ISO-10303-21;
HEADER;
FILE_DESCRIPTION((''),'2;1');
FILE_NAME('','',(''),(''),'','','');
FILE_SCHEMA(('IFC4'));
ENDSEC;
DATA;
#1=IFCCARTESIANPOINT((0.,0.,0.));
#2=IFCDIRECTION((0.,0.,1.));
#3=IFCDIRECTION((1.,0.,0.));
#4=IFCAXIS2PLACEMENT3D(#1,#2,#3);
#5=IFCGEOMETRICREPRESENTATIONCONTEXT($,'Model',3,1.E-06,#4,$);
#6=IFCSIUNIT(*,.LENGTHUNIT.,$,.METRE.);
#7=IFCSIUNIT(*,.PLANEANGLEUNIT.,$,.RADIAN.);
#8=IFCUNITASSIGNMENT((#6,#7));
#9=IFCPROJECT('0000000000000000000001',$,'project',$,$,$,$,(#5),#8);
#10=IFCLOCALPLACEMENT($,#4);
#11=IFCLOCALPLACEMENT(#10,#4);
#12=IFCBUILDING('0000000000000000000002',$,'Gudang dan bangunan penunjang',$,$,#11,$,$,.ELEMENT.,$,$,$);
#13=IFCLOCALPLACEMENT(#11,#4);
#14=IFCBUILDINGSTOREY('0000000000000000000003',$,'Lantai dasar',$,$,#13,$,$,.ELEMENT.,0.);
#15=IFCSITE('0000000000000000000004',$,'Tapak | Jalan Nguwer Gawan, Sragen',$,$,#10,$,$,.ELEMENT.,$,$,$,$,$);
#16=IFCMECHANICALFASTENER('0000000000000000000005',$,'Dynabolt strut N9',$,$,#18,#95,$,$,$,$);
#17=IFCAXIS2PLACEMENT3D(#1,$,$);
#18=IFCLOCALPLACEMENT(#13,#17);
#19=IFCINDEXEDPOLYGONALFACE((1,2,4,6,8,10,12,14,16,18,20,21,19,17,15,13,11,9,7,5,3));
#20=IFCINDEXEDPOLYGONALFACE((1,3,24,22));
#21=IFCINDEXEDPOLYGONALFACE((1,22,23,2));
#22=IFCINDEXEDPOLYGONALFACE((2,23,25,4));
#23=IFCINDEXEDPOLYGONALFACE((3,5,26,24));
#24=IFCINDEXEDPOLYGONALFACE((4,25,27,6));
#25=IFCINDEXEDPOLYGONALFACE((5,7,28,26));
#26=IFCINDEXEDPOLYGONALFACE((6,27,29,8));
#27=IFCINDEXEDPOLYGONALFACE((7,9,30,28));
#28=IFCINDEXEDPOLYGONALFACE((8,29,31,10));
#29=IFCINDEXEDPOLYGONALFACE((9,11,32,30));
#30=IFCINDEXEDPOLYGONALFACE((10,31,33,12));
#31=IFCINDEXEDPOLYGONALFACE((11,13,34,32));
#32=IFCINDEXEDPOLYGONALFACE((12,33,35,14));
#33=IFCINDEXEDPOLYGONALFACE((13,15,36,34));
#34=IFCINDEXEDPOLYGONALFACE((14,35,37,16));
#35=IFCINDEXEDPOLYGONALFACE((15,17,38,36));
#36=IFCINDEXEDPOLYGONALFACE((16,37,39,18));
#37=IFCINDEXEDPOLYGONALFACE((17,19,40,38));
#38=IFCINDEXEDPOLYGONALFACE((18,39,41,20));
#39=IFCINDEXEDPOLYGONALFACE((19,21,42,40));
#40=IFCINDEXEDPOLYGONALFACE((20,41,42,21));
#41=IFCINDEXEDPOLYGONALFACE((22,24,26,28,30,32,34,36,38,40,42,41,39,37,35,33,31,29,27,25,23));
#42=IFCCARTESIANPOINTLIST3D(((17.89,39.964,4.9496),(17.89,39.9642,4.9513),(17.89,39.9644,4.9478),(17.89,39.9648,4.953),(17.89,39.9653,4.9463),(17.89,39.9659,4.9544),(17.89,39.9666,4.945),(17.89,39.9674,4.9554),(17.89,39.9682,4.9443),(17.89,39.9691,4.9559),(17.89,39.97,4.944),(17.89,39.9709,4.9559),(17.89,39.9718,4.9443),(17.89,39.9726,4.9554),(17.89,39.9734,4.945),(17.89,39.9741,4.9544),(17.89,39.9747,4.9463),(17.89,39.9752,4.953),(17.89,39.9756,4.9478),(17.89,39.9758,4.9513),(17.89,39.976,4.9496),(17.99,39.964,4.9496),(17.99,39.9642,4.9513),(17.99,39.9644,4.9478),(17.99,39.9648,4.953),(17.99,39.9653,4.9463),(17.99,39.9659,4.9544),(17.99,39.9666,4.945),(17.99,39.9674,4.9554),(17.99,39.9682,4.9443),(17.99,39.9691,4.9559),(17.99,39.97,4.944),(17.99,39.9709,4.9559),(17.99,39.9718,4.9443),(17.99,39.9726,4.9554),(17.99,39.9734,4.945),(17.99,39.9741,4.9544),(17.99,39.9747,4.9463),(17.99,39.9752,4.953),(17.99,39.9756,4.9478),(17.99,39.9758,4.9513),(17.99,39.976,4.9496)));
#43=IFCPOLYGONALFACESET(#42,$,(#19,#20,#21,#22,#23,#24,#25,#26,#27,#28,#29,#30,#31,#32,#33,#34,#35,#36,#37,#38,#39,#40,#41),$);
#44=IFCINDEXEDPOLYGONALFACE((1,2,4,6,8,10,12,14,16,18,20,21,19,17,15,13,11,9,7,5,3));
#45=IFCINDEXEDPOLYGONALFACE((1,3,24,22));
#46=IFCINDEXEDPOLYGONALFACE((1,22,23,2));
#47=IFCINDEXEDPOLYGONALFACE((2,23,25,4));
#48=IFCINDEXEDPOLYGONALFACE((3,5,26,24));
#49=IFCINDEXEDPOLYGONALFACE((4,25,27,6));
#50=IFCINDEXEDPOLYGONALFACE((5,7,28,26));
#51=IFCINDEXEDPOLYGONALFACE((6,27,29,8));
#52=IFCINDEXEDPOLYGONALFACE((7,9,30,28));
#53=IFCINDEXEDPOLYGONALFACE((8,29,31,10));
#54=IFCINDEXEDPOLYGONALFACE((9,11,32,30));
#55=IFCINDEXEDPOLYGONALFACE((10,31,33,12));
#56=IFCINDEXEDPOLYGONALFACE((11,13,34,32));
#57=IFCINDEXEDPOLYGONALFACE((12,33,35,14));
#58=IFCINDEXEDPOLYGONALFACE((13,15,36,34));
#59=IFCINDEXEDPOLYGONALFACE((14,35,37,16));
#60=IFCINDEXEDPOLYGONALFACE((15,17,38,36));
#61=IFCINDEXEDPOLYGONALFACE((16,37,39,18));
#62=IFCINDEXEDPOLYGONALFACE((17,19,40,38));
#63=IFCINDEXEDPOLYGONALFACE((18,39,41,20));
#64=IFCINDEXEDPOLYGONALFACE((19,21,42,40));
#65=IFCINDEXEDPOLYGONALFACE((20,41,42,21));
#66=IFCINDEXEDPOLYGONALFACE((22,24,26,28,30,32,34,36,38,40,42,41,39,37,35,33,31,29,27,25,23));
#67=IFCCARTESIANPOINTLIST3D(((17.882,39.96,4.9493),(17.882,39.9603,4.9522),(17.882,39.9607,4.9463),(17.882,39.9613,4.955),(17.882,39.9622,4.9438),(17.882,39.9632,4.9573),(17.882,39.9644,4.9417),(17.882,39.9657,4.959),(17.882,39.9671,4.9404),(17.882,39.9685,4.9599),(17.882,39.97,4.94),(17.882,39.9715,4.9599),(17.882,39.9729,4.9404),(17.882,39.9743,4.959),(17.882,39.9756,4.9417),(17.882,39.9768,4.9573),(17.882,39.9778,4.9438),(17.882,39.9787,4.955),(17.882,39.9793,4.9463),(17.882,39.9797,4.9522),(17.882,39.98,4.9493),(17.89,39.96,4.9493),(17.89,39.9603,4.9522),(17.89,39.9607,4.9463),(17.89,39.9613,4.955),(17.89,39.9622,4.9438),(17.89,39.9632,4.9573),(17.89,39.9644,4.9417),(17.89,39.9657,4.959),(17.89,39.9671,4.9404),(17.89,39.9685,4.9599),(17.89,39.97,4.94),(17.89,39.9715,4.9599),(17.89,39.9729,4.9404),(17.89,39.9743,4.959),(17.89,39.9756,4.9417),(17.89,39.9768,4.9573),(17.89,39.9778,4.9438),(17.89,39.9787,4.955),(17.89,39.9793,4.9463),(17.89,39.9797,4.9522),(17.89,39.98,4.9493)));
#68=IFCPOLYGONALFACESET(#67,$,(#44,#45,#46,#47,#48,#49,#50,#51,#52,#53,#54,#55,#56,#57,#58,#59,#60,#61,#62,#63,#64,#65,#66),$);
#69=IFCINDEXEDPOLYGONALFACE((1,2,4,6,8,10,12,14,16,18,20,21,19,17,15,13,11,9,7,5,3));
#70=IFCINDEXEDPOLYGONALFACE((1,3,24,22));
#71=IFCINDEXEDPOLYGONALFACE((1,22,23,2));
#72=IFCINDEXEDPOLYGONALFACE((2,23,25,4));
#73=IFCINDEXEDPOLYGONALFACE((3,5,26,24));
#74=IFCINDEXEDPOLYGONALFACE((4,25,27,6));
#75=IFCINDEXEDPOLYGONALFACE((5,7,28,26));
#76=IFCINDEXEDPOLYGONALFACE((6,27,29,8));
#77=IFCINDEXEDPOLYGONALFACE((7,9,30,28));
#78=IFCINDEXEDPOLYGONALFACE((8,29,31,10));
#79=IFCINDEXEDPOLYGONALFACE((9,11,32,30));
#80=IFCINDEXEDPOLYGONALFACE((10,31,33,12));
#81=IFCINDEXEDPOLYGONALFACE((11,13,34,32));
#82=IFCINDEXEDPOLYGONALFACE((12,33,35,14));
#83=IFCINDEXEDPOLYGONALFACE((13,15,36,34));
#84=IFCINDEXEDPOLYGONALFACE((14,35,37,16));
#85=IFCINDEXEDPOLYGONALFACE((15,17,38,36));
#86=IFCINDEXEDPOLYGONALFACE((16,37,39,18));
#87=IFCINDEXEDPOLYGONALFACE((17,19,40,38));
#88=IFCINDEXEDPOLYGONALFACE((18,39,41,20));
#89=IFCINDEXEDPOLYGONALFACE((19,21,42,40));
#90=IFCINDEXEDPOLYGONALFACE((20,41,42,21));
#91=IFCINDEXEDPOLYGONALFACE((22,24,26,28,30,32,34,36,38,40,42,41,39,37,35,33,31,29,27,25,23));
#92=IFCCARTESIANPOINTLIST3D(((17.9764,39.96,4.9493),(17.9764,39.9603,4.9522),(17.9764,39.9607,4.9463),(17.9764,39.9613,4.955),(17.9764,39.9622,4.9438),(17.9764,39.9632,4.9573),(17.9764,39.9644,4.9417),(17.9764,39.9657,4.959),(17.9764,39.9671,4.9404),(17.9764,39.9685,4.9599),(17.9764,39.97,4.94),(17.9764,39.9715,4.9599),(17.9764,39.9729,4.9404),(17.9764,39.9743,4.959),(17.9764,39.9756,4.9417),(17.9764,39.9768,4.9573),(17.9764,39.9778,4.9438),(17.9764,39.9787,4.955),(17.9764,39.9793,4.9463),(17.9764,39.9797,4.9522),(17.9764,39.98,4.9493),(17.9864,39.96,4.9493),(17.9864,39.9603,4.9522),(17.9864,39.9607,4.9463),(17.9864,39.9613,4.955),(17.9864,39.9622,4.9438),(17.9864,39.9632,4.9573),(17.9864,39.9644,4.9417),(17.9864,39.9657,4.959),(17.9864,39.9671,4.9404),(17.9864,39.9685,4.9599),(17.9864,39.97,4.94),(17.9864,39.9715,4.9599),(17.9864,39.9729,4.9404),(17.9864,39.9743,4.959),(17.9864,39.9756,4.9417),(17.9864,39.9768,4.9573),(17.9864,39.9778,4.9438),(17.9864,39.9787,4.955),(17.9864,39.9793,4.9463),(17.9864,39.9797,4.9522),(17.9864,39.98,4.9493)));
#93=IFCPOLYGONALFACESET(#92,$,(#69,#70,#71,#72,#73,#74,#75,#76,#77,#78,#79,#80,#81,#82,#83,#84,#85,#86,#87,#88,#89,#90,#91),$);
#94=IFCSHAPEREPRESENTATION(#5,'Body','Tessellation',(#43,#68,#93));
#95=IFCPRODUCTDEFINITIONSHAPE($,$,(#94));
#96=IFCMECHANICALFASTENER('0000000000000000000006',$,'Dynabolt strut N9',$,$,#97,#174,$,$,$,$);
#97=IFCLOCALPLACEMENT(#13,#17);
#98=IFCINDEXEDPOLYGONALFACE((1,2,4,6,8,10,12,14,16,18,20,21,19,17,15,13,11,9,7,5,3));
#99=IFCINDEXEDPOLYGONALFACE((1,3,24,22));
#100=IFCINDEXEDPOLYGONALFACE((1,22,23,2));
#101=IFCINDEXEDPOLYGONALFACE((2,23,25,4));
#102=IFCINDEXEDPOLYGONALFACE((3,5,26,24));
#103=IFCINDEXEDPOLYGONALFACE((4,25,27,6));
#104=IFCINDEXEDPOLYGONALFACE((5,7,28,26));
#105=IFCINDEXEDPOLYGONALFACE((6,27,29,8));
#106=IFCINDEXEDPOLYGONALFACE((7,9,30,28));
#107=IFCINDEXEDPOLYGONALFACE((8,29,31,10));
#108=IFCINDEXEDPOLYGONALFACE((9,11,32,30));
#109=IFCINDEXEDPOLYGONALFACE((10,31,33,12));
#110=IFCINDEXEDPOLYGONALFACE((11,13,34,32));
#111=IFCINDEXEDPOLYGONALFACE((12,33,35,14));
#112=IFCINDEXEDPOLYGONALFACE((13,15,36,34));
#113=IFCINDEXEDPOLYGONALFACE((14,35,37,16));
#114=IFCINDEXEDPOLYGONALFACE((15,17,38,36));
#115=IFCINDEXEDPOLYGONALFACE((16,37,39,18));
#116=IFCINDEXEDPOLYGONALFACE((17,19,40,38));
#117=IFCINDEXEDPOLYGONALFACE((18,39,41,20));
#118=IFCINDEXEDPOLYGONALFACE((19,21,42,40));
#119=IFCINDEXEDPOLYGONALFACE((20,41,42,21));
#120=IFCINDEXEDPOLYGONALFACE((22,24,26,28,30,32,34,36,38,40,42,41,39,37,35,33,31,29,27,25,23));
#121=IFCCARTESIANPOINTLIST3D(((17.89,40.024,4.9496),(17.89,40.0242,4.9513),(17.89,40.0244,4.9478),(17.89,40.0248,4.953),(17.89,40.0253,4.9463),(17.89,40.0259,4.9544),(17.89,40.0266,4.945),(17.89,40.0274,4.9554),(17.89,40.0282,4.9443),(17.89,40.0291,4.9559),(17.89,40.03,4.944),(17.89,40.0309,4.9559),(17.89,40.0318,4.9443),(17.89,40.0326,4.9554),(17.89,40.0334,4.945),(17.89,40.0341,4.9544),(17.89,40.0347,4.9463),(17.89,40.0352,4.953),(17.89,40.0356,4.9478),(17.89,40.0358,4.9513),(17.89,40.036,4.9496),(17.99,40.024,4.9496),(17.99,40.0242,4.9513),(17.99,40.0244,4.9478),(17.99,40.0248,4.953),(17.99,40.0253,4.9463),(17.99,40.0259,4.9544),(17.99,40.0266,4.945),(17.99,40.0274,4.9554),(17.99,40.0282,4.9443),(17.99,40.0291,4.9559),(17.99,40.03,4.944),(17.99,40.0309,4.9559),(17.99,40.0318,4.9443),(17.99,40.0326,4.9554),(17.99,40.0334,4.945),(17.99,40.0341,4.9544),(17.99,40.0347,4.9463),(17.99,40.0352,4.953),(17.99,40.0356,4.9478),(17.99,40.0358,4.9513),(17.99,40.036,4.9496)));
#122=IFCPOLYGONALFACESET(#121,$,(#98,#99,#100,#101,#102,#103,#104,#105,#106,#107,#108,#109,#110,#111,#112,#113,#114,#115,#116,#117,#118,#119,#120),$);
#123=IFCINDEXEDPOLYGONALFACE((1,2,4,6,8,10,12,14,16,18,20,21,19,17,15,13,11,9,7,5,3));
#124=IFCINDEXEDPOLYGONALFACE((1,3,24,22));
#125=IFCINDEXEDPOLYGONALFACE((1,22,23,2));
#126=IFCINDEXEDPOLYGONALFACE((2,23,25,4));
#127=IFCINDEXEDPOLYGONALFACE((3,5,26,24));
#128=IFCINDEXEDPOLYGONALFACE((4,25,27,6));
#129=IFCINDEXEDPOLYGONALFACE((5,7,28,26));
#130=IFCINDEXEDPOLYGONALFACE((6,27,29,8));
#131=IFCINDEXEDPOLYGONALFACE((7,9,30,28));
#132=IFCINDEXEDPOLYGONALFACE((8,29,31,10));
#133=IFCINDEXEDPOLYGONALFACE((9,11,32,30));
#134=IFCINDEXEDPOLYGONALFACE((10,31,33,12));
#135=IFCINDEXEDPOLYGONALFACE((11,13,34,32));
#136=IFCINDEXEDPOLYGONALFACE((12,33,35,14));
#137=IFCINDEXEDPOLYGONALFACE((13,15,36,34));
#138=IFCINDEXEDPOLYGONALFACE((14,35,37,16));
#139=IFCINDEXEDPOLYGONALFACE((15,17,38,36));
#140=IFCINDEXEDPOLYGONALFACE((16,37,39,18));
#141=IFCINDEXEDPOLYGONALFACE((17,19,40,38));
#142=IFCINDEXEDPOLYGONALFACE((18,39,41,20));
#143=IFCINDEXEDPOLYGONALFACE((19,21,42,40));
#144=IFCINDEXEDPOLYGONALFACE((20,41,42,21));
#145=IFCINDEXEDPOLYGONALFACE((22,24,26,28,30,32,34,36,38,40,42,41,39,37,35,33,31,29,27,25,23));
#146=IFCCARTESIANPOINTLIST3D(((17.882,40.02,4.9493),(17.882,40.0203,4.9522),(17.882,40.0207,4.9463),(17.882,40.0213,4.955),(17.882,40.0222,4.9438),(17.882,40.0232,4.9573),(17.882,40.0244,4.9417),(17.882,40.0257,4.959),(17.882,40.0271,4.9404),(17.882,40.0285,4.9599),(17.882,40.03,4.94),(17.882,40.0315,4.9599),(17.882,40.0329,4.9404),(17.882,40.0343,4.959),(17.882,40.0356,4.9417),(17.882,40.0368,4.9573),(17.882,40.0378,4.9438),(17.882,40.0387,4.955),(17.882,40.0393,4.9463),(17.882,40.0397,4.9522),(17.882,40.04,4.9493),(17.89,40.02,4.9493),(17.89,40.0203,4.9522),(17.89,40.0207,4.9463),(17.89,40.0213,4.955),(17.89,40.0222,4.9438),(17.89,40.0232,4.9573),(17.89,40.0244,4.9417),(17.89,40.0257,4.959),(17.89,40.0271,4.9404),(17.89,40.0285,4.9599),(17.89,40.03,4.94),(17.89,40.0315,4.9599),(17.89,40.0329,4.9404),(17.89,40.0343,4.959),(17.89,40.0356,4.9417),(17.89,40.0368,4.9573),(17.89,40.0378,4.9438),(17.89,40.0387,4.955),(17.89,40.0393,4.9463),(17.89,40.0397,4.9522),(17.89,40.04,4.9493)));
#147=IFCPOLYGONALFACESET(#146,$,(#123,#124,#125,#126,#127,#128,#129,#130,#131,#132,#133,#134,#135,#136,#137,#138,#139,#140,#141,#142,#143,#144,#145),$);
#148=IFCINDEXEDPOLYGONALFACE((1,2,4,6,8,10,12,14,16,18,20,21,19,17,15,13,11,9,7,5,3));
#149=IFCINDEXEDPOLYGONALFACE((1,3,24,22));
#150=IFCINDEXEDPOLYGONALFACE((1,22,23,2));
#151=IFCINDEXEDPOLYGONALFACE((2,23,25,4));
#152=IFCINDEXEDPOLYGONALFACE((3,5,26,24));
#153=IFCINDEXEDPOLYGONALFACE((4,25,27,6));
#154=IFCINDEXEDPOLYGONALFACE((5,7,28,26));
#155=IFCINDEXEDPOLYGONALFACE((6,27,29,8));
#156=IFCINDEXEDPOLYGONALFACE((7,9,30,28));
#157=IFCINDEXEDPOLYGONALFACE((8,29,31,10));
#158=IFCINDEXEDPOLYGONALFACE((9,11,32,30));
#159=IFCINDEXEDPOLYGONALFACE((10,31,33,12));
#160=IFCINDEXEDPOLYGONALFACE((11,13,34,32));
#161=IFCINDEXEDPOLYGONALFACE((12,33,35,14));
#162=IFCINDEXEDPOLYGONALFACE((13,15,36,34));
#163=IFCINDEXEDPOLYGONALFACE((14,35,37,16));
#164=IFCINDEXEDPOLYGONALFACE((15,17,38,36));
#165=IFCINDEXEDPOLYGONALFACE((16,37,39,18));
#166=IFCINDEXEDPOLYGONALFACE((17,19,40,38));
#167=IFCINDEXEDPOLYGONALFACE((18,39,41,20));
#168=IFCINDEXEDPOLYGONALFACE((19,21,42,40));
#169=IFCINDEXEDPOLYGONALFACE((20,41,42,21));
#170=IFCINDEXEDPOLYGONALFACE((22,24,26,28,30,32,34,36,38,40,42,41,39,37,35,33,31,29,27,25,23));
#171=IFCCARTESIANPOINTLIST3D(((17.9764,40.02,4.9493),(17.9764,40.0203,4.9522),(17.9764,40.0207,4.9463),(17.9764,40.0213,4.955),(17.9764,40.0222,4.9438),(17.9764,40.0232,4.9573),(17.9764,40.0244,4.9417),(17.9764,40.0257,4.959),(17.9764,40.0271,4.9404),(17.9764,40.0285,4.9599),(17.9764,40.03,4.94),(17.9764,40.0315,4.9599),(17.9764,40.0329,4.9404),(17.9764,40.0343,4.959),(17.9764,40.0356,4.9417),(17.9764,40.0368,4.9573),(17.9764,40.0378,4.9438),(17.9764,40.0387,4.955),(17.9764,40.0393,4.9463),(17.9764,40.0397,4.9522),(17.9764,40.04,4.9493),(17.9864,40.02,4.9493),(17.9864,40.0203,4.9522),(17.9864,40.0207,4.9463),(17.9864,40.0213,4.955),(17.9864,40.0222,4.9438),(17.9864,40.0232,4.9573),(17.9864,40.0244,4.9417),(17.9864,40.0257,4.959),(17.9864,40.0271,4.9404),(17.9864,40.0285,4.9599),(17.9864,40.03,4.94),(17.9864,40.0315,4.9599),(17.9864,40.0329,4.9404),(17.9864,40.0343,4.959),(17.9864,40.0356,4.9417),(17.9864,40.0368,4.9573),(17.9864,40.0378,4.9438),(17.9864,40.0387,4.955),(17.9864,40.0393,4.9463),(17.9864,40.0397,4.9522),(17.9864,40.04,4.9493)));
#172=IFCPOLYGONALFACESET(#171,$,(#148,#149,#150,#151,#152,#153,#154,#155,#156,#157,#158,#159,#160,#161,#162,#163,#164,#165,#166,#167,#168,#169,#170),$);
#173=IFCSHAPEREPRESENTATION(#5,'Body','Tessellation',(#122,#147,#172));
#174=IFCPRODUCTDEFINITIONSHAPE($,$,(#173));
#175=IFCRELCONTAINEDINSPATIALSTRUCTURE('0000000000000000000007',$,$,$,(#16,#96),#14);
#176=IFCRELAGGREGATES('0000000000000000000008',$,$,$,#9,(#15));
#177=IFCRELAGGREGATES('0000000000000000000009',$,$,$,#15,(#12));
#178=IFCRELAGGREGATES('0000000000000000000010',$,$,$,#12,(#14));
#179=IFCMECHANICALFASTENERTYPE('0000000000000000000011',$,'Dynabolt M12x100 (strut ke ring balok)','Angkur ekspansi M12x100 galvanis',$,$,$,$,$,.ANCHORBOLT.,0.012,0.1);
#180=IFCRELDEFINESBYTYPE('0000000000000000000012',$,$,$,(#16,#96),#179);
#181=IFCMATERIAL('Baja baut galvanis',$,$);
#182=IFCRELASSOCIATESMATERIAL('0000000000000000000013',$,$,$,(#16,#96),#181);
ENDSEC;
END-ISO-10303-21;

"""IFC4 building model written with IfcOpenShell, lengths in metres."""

from ifc_helpers import new_model, si_unit, frame, origin_with_axes, place, context, project, spatial, circle, extrude, source, transform, mapped, material, type_object, type_shapes, element, save


model = new_model("IFC4")

# Units and contexts
model_context = context("Model", 3, precision=1e-06, world=origin_with_axes())
ifc_project = project(units=[si_unit("LENGTHUNIT", "METRE"), si_unit("PLANEANGLEUNIT", "RADIAN")], contexts=[model_context])

# Site, building, storey
site_placement = place(None, origin_with_axes())
site = spatial("IfcSite", under=ifc_project, at=site_placement, Name="Tapak | Jalan Nguwer Gawan, Sragen", CompositionType="ELEMENT")
building_placement = place(site_placement, origin_with_axes())
building = spatial("IfcBuilding", under=site, at=building_placement, Name="Gudang dan bangunan penunjang", CompositionType="ELEMENT")
storey_placement = place(building_placement, origin_with_axes())
storey = spatial("IfcBuildingStorey", under=building, at=storey_placement, Name="Lantai dasar", CompositionType="ELEMENT", Elevation=0.0)

# Mechanical fasteners
ifc_material = material(Name="Baja baut galvanis")
mechanical_fastener_type = type_object("IfcMechanicalFastenerType", Name="Dynabolt M12x100 (strut ke ring balok)", Description="Angkur ekspansi M12x100 galvanis", NominalDiameter=0.012, NominalLength=0.1, PredefinedType="ANCHORBOLT")
shared_shape = source(origin_with_axes(), model_context, "Body", "SweptSolid", [
    extrude(circle(Radius=0.006), origin_with_axes(), (0.0, 0.0, 1.0), 0.1),
    extrude(circle(Radius=0.01), frame((0.0, 0.0, -0.008), z_axis=(0.0, 0.0, 1.0), x_axis=(1.0, 0.0, 0.0)), (0.0, 0.0, 1.0), 0.008),
    extrude(circle(Radius=0.01), frame((0.0, 0.0, 0.0864), z_axis=(0.0, 0.0, 1.0), x_axis=(1.0, 0.0, 0.0)), (0.0, 0.0, 1.0), 0.01),
])
type_shapes(mechanical_fastener_type, [shared_shape])
placement = place(None, origin_with_axes())
element("IfcMechanicalFastener", 1, at=placement, inside=storey, type_object=mechanical_fastener_type, material=ifc_material, Name="Dynabolt strut N9", context=model_context, shape_type="MappedRepresentation", body=[
    mapped(shared_shape, transform((17.89, 39.97, 4.95), x_axis=(0.0, 0.0, -1.0), y_axis=(0.0, 1.0, 0.0), z_axis=(1.0, 0.0, 0.0), scale=1.0)),
])
element("IfcMechanicalFastener", 2, at=placement, inside=storey, type_object=mechanical_fastener_type, material=ifc_material, Name="Dynabolt strut N9", context=model_context, shape_type="MappedRepresentation", body=[
    mapped(shared_shape, transform((17.89, 40.03, 4.95), x_axis=(0.0, 0.0, -1.0), y_axis=(0.0, 1.0, 0.0), z_axis=(1.0, 0.0, 0.0), scale=1.0)),
])

save(model, "model.ifc")
